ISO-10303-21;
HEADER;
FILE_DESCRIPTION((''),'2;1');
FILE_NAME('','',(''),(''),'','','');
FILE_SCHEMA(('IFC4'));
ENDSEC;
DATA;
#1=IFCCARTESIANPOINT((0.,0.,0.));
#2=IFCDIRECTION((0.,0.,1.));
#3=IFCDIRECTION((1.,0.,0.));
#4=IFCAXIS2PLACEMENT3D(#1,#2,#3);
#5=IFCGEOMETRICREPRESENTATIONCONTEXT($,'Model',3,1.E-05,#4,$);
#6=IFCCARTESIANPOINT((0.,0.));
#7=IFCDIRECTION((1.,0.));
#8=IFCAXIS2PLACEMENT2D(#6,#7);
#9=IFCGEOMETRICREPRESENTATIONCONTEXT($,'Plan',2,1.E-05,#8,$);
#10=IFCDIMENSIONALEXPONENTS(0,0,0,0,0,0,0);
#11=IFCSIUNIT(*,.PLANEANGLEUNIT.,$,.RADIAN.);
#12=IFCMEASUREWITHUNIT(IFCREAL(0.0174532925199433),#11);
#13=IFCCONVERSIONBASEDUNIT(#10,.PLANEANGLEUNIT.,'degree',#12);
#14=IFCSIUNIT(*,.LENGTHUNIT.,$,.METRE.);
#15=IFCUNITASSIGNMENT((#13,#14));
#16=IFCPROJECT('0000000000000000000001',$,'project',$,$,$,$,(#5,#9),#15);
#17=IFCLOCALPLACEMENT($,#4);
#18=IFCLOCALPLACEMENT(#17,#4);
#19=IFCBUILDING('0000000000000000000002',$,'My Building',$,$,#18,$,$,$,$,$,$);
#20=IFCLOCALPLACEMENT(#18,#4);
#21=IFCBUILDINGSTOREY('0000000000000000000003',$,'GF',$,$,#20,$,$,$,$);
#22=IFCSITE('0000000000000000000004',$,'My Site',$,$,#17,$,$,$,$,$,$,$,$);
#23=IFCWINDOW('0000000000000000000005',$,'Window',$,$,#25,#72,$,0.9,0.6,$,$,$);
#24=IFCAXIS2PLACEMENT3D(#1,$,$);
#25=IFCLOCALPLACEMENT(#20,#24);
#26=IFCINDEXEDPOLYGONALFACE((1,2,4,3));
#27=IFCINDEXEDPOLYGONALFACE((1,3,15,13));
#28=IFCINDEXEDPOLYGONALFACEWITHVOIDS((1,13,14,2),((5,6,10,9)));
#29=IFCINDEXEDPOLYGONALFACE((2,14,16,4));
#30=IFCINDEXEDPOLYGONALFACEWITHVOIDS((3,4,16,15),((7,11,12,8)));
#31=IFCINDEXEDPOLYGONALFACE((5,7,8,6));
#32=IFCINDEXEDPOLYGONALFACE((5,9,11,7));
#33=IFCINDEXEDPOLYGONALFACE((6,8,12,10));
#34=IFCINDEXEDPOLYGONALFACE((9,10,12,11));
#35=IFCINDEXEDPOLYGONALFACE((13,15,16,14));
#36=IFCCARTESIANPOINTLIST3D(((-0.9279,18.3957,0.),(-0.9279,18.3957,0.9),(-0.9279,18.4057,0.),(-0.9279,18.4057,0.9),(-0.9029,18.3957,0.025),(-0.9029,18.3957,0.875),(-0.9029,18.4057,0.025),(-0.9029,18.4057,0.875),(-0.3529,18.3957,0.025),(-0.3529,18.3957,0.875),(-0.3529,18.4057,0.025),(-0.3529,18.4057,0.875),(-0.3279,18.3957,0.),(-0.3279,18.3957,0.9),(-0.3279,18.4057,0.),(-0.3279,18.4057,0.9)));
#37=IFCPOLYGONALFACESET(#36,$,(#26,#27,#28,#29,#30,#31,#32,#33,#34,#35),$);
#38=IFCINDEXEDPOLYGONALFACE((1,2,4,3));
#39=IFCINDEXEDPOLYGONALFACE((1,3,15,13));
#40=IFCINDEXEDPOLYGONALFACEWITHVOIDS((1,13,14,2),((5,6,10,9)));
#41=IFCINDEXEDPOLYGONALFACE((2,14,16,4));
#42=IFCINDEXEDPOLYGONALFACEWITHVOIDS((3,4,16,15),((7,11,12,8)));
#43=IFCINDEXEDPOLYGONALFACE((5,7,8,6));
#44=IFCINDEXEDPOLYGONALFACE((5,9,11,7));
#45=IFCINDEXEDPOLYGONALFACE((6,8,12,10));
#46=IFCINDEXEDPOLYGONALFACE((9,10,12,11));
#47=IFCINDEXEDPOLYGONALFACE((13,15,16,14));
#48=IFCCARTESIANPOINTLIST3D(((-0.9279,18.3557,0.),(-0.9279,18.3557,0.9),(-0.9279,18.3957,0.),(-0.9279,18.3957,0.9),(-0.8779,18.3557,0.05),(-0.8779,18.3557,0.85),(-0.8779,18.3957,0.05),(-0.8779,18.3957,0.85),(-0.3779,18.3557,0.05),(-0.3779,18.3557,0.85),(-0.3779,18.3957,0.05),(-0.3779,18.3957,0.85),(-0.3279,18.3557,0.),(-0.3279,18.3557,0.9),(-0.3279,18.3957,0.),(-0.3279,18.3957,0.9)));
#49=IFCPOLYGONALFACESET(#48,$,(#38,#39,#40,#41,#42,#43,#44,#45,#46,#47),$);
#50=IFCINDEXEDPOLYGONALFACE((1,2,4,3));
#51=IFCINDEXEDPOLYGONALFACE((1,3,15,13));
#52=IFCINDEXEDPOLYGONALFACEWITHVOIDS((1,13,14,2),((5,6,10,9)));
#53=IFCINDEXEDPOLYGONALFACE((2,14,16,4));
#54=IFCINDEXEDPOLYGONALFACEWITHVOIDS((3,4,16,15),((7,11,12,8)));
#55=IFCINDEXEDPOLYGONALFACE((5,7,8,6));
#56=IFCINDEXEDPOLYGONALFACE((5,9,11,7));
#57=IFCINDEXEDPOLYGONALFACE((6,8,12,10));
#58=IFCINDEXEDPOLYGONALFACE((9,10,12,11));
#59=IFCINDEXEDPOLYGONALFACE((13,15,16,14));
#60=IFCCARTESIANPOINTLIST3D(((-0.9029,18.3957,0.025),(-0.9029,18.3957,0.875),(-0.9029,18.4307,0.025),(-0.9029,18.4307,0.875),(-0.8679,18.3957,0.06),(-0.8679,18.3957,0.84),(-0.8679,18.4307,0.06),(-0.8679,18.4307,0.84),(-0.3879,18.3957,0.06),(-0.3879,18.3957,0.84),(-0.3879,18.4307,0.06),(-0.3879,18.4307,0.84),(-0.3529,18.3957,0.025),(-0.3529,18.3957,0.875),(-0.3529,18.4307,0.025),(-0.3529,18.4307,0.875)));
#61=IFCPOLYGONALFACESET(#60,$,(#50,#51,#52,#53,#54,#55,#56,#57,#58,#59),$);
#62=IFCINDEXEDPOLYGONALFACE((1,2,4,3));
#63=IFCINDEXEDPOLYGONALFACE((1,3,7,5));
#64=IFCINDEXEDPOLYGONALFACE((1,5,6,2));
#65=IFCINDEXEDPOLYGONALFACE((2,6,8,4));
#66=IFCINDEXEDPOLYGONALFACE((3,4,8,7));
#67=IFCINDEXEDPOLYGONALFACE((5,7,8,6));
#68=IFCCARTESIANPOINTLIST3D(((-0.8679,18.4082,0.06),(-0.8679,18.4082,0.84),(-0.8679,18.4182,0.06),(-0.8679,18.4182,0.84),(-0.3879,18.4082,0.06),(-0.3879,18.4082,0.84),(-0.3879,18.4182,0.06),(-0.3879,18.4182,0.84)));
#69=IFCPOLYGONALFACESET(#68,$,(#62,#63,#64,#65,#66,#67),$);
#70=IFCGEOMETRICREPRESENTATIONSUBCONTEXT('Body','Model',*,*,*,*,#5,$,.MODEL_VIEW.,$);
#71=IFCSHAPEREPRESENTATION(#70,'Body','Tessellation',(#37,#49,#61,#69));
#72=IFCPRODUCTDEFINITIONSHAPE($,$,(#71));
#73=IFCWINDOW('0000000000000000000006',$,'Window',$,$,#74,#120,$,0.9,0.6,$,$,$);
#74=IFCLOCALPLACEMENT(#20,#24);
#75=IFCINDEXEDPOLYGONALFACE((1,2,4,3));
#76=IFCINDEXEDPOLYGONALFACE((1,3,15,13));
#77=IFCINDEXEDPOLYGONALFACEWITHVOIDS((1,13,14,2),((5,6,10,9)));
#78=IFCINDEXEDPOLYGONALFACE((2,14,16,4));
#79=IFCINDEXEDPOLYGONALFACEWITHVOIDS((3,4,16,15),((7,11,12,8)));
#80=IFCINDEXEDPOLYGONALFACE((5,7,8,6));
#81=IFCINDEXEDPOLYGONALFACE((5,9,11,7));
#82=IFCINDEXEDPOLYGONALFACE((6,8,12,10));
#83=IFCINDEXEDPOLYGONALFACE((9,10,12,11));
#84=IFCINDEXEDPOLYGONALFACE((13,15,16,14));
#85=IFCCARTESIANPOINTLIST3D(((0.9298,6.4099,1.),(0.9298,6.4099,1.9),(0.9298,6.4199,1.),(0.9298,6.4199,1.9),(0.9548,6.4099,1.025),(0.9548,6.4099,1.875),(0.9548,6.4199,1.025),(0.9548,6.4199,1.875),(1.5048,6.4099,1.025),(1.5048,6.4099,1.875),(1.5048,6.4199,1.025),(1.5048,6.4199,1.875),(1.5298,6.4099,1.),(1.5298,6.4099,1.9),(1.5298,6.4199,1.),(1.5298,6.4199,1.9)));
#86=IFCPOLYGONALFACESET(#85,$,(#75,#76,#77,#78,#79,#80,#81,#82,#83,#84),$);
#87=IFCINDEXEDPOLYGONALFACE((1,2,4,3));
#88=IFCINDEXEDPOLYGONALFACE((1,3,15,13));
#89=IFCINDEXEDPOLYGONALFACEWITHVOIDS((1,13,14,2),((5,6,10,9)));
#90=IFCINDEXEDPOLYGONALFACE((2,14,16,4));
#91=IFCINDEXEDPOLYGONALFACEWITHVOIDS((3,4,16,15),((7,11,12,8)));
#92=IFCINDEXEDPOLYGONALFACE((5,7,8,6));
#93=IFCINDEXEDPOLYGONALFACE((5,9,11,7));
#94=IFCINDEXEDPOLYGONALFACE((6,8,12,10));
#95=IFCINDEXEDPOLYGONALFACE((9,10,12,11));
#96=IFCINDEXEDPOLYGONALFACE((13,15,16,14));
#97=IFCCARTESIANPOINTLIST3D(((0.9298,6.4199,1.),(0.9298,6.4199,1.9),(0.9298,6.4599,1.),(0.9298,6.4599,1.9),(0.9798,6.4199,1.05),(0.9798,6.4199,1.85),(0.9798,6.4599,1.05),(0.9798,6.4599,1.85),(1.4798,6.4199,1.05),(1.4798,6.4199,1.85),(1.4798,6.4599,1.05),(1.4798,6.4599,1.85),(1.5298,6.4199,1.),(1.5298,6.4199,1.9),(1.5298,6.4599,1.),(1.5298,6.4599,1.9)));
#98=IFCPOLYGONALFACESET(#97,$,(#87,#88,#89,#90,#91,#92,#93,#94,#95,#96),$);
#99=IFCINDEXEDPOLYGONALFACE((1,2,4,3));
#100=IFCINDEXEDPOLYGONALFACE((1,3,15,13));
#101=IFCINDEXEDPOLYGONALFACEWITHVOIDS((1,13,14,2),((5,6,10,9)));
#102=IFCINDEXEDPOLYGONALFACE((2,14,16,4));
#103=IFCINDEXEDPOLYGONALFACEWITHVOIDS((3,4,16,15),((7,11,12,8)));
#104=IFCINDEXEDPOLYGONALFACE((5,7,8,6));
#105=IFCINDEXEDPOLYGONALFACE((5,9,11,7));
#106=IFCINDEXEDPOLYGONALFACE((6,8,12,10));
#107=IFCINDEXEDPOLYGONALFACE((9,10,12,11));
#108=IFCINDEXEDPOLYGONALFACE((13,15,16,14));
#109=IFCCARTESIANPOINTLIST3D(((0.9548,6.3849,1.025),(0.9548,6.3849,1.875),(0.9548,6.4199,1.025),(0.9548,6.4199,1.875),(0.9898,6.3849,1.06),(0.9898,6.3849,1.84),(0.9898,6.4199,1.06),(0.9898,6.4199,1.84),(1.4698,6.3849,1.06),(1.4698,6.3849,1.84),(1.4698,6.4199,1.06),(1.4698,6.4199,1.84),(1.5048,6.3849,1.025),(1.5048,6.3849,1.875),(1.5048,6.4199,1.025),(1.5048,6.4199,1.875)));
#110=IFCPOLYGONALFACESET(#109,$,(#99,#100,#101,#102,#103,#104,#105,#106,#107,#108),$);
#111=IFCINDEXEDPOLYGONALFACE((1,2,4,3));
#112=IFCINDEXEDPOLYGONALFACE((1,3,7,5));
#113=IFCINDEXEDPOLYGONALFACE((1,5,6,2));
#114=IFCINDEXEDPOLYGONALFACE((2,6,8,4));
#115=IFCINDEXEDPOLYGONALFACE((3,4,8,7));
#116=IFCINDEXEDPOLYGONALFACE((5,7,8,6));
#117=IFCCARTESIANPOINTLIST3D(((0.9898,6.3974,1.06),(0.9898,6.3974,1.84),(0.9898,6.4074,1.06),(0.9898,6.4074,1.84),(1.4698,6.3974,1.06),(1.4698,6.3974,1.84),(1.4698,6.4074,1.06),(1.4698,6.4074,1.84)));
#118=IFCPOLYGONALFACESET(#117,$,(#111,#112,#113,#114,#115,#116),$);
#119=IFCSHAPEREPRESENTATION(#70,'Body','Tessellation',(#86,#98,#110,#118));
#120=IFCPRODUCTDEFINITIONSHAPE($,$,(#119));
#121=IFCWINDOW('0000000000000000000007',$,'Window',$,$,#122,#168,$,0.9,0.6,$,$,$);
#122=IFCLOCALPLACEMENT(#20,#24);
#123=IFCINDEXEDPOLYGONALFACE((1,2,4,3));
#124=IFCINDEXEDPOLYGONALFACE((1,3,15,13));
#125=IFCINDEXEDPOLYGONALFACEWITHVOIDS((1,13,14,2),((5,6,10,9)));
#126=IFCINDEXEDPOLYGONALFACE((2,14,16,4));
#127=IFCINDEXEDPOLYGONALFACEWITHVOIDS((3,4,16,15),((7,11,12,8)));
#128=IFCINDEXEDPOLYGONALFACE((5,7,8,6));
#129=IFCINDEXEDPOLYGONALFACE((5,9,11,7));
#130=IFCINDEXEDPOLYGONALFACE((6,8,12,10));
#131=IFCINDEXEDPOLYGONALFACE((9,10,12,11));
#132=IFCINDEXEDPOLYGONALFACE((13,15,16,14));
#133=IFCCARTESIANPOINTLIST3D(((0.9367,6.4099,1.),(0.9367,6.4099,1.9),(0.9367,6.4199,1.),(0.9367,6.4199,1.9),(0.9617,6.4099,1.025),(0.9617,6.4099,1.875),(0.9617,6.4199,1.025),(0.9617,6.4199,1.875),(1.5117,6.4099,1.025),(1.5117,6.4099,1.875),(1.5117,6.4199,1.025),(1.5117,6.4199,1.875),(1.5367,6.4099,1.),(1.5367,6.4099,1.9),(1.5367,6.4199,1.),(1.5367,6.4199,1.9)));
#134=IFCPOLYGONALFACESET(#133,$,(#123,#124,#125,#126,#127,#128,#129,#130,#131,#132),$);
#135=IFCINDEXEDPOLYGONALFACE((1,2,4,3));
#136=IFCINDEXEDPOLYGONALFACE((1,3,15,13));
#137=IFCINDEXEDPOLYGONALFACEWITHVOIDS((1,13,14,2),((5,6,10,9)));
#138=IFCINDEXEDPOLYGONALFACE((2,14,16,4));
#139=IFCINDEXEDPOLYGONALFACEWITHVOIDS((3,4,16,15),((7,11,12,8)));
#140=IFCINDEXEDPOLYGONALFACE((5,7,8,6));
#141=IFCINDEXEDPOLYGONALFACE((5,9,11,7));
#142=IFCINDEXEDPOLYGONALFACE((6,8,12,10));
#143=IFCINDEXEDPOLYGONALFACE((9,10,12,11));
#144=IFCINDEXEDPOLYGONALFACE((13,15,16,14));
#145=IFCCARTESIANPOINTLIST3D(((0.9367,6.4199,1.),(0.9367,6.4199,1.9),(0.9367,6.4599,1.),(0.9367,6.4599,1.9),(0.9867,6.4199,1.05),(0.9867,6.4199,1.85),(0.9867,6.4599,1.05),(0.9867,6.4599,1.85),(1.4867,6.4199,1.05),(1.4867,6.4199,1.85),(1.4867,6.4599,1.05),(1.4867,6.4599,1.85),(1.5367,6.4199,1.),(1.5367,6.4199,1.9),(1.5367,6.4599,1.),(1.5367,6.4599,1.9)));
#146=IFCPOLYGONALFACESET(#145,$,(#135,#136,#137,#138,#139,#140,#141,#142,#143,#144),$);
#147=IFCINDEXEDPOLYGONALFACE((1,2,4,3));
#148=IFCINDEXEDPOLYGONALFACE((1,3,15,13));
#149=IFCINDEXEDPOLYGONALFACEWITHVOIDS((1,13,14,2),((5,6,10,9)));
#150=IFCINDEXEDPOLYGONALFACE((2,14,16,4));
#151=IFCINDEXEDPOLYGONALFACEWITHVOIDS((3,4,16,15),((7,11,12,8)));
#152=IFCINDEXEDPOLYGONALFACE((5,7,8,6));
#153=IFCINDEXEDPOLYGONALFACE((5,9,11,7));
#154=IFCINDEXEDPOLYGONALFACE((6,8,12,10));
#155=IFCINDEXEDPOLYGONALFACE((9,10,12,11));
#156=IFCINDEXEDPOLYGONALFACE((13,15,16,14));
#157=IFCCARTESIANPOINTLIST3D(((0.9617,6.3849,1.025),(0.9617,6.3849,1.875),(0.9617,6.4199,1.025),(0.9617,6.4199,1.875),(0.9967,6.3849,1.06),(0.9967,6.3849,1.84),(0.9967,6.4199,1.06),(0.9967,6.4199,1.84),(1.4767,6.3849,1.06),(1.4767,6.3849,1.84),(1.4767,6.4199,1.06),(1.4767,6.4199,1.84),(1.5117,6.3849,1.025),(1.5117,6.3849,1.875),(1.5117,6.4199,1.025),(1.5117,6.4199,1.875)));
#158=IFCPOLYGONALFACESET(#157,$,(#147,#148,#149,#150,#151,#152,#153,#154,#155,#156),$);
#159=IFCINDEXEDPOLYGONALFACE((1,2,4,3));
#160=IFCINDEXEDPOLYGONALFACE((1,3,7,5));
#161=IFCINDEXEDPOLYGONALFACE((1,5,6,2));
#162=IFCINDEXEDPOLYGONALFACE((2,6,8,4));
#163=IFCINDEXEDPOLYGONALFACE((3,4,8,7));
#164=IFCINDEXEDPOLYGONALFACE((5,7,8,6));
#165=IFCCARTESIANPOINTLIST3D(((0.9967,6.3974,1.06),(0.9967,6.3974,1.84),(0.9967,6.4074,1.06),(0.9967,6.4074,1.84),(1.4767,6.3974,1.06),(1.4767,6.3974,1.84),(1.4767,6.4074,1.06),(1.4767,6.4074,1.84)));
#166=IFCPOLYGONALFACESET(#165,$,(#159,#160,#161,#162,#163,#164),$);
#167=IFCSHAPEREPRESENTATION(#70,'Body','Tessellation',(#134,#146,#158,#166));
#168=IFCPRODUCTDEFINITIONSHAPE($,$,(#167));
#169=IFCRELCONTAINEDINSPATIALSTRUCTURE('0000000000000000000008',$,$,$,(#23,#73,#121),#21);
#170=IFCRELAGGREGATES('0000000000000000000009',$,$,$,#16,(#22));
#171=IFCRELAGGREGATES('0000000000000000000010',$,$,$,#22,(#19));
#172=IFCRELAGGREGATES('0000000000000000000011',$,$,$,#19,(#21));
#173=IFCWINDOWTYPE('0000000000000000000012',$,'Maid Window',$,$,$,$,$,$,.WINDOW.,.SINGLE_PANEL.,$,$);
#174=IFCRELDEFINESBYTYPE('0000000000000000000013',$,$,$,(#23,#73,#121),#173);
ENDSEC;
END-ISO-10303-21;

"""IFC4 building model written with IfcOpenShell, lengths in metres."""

from ifc_helpers import new_model, entity, si_unit, converted_unit, frame, origin_with_axes, origin_2d_with_axis, place, context, subcontext, project, spatial, line, indexed_curve, outline, extrude, shape, source, transform, mapped, type_object, type_shapes, element, save


model = new_model("IFC4")

# Units and contexts
model_context = context("Model", 3, precision=1e-05, world=origin_with_axes())
plan_context = context("Plan", 2, precision=1e-05, world=origin_2d_with_axis())
body_context_1 = subcontext(model_context, "Body", "Model", "MODEL_VIEW")
body_context_2 = subcontext(plan_context, "Body", "Plan", "PLAN_VIEW")
ifc_project = project(units=[converted_unit("PLANEANGLEUNIT", "degree", entity("IfcReal", 0.0174532925199433), si_unit("PLANEANGLEUNIT", "RADIAN"), dimensions=[0, 0, 0, 0, 0, 0, 0]), si_unit("LENGTHUNIT", "METRE")], contexts=[model_context, plan_context])

# Site, building, storey
site_placement = place(None, origin_with_axes())
site = spatial("IfcSite", under=ifc_project, at=site_placement, Name="My Site")
building_placement = place(site_placement, origin_with_axes())
building = spatial("IfcBuilding", under=site, at=building_placement, Name="My Building")
storey_placement = place(building_placement, origin_with_axes())
storey = spatial("IfcBuildingStorey", under=building, at=storey_placement, Name="GF")

# Shared definitions
window_type_1 = type_object("IfcWindowType", Name="Maid Window", PartitioningType="SINGLE_PANEL", PredefinedType="WINDOW")
shared_shape_1 = source(origin_with_axes(), body_context_1, "Body", "SweptSolid", [
    extrude(outline(indexed_curve([(0.0, 0.0), (0.6, 0.0), (0.6, 0.9), (0.0, 0.9)], segments=[line(1, 2, 3, 4, 1)]), holes=[indexed_curve([(0.025, 0.025), (0.575, 0.025), (0.575, 0.875), (0.025, 0.875)], segments=[line(1, 2, 3, 4, 1)])]), frame((0.0, 0.09, 0.0), z_axis=(0.0, -1.0, 0.0), x_axis=(1.0, 0.0, 0.0)), (0.0, 0.0, -1.0), 0.01),
    extrude(outline(indexed_curve([(0.0, 0.0), (0.6, 0.0), (0.6, 0.9), (0.0, 0.9)], segments=[line(1, 2, 3, 4, 1)]), holes=[indexed_curve([(0.05, 0.05), (0.55, 0.05), (0.55, 0.85), (0.05, 0.85)], segments=[line(1, 2, 3, 4, 1)])]), frame((0.0, 0.05, 0.0), z_axis=(0.0, -1.0, 0.0), x_axis=(1.0, 0.0, 0.0)), (0.0, 0.0, -1.0), 0.04),
    extrude(outline(indexed_curve([(0.0, 0.0), (0.55, 0.0), (0.55, 0.85), (0.0, 0.85)], segments=[line(1, 2, 3, 4, 1)]), holes=[indexed_curve([(0.035, 0.035), (0.515, 0.035), (0.515, 0.815), (0.035, 0.815)], segments=[line(1, 2, 3, 4, 1)])]), frame((0.025, 0.09, 0.025), z_axis=(0.0, -1.0, 0.0), x_axis=(1.0, 0.0, 0.0)), (0.0, 0.0, -1.0), 0.035),
    extrude(outline(indexed_curve([(0.035, 0.035), (0.515, 0.035), (0.515, 0.815), (0.035, 0.815)], segments=[line(1, 2, 3, 4, 1)])), frame((0.025, 0.1025, 0.025), z_axis=(0.0, -1.0, 0.0), x_axis=(1.0, 0.0, 0.0)), (0.0, 0.0, -1.0), 0.01),
])
shared_shape_2 = source(origin_with_axes(), body_context_2, "Body", "Curve2D", [
    entity("IfcIndexedPolyCurve", entity("IfcCartesianPointList2D", [[0.05, 0.05], [0.55, 0.05]])),
    entity("IfcIndexedPolyCurve", entity("IfcCartesianPointList2D", [[0.0, 0.1], [0.025, 0.1], [0.025, 0.09], [0.05, 0.09], [0.05, 0.05], [0.0, 0.05]]), [entity("IfcLineIndex", [1, 2, 3, 4, 5, 6, 1])]),
    entity("IfcIndexedPolyCurve", entity("IfcCartesianPointList2D", [[0.6, 0.1], [0.575, 0.1], [0.575, 0.09], [0.55, 0.09], [0.55, 0.05], [0.6, 0.05]]), [entity("IfcLineIndex", [1, 2, 3, 4, 5, 6, 1])]),
    entity("IfcIndexedPolyCurve", entity("IfcCartesianPointList2D", [[0.025, 0.09], [0.06, 0.09], [0.06, 0.125], [0.025, 0.125]]), [entity("IfcLineIndex", [1, 2, 3, 4, 1])]),
    entity("IfcIndexedPolyCurve", entity("IfcCartesianPointList2D", [[0.575, 0.09], [0.54, 0.09], [0.54, 0.125], [0.575, 0.125]]), [entity("IfcLineIndex", [1, 2, 3, 4, 1])]),
    entity("IfcIndexedPolyCurve", entity("IfcCartesianPointList2D", [[0.06, 0.09], [0.54, 0.09]])),
    entity("IfcIndexedPolyCurve", entity("IfcCartesianPointList2D", [[0.06, 0.125], [0.54, 0.125]])),
    entity("IfcIndexedPolyCurve", entity("IfcCartesianPointList2D", [[0.06, 0.1075], [0.54, 0.1075]])),
])
type_shapes(window_type_1, [shared_shape_1, shared_shape_2])

# Windows
window_1_placement = place(storey_placement, frame((-0.9279, 18.3057, 0.0), z_axis=(0.0, 0.0, 1.0), x_axis=(1.0, 0.0, 0.0)))
element("IfcWindow", 1, at=window_1_placement, inside=storey, type_object=window_type_1, Name="Window", OverallHeight=0.9, OverallWidth=0.6, shapes=[
    shape(body_context_1, "Body", "MappedRepresentation", [mapped(shared_shape_1, transform((0.0, 0.0, 0.0), x_axis=(1.0, 0.0, 0.0), y_axis=(0.0, 1.0, 0.0), z_axis=(0.0, 0.0, 1.0), scale=1.0))]),
    shape(body_context_2, "Body", "MappedRepresentation", [mapped(shared_shape_2, transform((0.0, 0.0, 0.0), x_axis=(1.0, 0.0, 0.0), y_axis=(0.0, 1.0, 0.0), z_axis=(0.0, 0.0, 1.0), scale=1.0))]),
])
placement_1 = place(storey_placement, frame((4.2266, 6.5099, 0.0), z_axis=(0.0, 0.0, 1.0), x_axis=(-1.0, 0.0, 0.0)))
placement_2 = place(placement_1, frame((2.6968, 0.0, 1.0), z_axis=(0.0, 0.0, 1.0), x_axis=(1.0, 0.0, 0.0)))
window_2_placement = place(placement_2, frame((0.0, 0.0, 0.0), z_axis=(0.0, 0.0, 1.0), x_axis=(1.0, 0.0, 0.0)))
element("IfcWindow", 2, at=window_2_placement, inside=storey, type_object=window_type_1, Name="Window", OverallHeight=0.9, OverallWidth=0.6, shapes=[
    shape(body_context_1, "Body", "MappedRepresentation", [mapped(shared_shape_1, transform((0.0, 0.0, 0.0), x_axis=(1.0, 0.0, 0.0), y_axis=(0.0, 1.0, 0.0), z_axis=(0.0, 0.0, 1.0), scale=1.0))]),
    shape(body_context_2, "Body", "MappedRepresentation", [mapped(shared_shape_2, transform((0.0, 0.0, 0.0), x_axis=(1.0, 0.0, 0.0), y_axis=(0.0, 1.0, 0.0), z_axis=(0.0, 0.0, 1.0), scale=1.0))]),
])
placement_3 = place(placement_1, frame((2.6899, 0.0, 1.0), z_axis=(0.0, 0.0, 1.0), x_axis=(1.0, 0.0, 0.0)))
window_3_placement = place(placement_3, frame((0.0, 0.0, 0.0), z_axis=(0.0, 0.0, 1.0), x_axis=(1.0, 0.0, 0.0)))
element("IfcWindow", 3, at=window_3_placement, inside=storey, type_object=window_type_1, Name="Window", OverallHeight=0.9, OverallWidth=0.6, shapes=[
    shape(body_context_1, "Body", "MappedRepresentation", [mapped(shared_shape_1, transform((0.0, 0.0, 0.0), x_axis=(1.0, 0.0, 0.0), y_axis=(0.0, 1.0, 0.0), z_axis=(0.0, 0.0, 1.0), scale=1.0))]),
    shape(body_context_2, "Body", "MappedRepresentation", [mapped(shared_shape_2, transform((0.0, 0.0, 0.0), x_axis=(1.0, 0.0, 0.0), y_axis=(0.0, 1.0, 0.0), z_axis=(0.0, 0.0, 1.0), scale=1.0))]),
])

save(model, "model.ifc")
